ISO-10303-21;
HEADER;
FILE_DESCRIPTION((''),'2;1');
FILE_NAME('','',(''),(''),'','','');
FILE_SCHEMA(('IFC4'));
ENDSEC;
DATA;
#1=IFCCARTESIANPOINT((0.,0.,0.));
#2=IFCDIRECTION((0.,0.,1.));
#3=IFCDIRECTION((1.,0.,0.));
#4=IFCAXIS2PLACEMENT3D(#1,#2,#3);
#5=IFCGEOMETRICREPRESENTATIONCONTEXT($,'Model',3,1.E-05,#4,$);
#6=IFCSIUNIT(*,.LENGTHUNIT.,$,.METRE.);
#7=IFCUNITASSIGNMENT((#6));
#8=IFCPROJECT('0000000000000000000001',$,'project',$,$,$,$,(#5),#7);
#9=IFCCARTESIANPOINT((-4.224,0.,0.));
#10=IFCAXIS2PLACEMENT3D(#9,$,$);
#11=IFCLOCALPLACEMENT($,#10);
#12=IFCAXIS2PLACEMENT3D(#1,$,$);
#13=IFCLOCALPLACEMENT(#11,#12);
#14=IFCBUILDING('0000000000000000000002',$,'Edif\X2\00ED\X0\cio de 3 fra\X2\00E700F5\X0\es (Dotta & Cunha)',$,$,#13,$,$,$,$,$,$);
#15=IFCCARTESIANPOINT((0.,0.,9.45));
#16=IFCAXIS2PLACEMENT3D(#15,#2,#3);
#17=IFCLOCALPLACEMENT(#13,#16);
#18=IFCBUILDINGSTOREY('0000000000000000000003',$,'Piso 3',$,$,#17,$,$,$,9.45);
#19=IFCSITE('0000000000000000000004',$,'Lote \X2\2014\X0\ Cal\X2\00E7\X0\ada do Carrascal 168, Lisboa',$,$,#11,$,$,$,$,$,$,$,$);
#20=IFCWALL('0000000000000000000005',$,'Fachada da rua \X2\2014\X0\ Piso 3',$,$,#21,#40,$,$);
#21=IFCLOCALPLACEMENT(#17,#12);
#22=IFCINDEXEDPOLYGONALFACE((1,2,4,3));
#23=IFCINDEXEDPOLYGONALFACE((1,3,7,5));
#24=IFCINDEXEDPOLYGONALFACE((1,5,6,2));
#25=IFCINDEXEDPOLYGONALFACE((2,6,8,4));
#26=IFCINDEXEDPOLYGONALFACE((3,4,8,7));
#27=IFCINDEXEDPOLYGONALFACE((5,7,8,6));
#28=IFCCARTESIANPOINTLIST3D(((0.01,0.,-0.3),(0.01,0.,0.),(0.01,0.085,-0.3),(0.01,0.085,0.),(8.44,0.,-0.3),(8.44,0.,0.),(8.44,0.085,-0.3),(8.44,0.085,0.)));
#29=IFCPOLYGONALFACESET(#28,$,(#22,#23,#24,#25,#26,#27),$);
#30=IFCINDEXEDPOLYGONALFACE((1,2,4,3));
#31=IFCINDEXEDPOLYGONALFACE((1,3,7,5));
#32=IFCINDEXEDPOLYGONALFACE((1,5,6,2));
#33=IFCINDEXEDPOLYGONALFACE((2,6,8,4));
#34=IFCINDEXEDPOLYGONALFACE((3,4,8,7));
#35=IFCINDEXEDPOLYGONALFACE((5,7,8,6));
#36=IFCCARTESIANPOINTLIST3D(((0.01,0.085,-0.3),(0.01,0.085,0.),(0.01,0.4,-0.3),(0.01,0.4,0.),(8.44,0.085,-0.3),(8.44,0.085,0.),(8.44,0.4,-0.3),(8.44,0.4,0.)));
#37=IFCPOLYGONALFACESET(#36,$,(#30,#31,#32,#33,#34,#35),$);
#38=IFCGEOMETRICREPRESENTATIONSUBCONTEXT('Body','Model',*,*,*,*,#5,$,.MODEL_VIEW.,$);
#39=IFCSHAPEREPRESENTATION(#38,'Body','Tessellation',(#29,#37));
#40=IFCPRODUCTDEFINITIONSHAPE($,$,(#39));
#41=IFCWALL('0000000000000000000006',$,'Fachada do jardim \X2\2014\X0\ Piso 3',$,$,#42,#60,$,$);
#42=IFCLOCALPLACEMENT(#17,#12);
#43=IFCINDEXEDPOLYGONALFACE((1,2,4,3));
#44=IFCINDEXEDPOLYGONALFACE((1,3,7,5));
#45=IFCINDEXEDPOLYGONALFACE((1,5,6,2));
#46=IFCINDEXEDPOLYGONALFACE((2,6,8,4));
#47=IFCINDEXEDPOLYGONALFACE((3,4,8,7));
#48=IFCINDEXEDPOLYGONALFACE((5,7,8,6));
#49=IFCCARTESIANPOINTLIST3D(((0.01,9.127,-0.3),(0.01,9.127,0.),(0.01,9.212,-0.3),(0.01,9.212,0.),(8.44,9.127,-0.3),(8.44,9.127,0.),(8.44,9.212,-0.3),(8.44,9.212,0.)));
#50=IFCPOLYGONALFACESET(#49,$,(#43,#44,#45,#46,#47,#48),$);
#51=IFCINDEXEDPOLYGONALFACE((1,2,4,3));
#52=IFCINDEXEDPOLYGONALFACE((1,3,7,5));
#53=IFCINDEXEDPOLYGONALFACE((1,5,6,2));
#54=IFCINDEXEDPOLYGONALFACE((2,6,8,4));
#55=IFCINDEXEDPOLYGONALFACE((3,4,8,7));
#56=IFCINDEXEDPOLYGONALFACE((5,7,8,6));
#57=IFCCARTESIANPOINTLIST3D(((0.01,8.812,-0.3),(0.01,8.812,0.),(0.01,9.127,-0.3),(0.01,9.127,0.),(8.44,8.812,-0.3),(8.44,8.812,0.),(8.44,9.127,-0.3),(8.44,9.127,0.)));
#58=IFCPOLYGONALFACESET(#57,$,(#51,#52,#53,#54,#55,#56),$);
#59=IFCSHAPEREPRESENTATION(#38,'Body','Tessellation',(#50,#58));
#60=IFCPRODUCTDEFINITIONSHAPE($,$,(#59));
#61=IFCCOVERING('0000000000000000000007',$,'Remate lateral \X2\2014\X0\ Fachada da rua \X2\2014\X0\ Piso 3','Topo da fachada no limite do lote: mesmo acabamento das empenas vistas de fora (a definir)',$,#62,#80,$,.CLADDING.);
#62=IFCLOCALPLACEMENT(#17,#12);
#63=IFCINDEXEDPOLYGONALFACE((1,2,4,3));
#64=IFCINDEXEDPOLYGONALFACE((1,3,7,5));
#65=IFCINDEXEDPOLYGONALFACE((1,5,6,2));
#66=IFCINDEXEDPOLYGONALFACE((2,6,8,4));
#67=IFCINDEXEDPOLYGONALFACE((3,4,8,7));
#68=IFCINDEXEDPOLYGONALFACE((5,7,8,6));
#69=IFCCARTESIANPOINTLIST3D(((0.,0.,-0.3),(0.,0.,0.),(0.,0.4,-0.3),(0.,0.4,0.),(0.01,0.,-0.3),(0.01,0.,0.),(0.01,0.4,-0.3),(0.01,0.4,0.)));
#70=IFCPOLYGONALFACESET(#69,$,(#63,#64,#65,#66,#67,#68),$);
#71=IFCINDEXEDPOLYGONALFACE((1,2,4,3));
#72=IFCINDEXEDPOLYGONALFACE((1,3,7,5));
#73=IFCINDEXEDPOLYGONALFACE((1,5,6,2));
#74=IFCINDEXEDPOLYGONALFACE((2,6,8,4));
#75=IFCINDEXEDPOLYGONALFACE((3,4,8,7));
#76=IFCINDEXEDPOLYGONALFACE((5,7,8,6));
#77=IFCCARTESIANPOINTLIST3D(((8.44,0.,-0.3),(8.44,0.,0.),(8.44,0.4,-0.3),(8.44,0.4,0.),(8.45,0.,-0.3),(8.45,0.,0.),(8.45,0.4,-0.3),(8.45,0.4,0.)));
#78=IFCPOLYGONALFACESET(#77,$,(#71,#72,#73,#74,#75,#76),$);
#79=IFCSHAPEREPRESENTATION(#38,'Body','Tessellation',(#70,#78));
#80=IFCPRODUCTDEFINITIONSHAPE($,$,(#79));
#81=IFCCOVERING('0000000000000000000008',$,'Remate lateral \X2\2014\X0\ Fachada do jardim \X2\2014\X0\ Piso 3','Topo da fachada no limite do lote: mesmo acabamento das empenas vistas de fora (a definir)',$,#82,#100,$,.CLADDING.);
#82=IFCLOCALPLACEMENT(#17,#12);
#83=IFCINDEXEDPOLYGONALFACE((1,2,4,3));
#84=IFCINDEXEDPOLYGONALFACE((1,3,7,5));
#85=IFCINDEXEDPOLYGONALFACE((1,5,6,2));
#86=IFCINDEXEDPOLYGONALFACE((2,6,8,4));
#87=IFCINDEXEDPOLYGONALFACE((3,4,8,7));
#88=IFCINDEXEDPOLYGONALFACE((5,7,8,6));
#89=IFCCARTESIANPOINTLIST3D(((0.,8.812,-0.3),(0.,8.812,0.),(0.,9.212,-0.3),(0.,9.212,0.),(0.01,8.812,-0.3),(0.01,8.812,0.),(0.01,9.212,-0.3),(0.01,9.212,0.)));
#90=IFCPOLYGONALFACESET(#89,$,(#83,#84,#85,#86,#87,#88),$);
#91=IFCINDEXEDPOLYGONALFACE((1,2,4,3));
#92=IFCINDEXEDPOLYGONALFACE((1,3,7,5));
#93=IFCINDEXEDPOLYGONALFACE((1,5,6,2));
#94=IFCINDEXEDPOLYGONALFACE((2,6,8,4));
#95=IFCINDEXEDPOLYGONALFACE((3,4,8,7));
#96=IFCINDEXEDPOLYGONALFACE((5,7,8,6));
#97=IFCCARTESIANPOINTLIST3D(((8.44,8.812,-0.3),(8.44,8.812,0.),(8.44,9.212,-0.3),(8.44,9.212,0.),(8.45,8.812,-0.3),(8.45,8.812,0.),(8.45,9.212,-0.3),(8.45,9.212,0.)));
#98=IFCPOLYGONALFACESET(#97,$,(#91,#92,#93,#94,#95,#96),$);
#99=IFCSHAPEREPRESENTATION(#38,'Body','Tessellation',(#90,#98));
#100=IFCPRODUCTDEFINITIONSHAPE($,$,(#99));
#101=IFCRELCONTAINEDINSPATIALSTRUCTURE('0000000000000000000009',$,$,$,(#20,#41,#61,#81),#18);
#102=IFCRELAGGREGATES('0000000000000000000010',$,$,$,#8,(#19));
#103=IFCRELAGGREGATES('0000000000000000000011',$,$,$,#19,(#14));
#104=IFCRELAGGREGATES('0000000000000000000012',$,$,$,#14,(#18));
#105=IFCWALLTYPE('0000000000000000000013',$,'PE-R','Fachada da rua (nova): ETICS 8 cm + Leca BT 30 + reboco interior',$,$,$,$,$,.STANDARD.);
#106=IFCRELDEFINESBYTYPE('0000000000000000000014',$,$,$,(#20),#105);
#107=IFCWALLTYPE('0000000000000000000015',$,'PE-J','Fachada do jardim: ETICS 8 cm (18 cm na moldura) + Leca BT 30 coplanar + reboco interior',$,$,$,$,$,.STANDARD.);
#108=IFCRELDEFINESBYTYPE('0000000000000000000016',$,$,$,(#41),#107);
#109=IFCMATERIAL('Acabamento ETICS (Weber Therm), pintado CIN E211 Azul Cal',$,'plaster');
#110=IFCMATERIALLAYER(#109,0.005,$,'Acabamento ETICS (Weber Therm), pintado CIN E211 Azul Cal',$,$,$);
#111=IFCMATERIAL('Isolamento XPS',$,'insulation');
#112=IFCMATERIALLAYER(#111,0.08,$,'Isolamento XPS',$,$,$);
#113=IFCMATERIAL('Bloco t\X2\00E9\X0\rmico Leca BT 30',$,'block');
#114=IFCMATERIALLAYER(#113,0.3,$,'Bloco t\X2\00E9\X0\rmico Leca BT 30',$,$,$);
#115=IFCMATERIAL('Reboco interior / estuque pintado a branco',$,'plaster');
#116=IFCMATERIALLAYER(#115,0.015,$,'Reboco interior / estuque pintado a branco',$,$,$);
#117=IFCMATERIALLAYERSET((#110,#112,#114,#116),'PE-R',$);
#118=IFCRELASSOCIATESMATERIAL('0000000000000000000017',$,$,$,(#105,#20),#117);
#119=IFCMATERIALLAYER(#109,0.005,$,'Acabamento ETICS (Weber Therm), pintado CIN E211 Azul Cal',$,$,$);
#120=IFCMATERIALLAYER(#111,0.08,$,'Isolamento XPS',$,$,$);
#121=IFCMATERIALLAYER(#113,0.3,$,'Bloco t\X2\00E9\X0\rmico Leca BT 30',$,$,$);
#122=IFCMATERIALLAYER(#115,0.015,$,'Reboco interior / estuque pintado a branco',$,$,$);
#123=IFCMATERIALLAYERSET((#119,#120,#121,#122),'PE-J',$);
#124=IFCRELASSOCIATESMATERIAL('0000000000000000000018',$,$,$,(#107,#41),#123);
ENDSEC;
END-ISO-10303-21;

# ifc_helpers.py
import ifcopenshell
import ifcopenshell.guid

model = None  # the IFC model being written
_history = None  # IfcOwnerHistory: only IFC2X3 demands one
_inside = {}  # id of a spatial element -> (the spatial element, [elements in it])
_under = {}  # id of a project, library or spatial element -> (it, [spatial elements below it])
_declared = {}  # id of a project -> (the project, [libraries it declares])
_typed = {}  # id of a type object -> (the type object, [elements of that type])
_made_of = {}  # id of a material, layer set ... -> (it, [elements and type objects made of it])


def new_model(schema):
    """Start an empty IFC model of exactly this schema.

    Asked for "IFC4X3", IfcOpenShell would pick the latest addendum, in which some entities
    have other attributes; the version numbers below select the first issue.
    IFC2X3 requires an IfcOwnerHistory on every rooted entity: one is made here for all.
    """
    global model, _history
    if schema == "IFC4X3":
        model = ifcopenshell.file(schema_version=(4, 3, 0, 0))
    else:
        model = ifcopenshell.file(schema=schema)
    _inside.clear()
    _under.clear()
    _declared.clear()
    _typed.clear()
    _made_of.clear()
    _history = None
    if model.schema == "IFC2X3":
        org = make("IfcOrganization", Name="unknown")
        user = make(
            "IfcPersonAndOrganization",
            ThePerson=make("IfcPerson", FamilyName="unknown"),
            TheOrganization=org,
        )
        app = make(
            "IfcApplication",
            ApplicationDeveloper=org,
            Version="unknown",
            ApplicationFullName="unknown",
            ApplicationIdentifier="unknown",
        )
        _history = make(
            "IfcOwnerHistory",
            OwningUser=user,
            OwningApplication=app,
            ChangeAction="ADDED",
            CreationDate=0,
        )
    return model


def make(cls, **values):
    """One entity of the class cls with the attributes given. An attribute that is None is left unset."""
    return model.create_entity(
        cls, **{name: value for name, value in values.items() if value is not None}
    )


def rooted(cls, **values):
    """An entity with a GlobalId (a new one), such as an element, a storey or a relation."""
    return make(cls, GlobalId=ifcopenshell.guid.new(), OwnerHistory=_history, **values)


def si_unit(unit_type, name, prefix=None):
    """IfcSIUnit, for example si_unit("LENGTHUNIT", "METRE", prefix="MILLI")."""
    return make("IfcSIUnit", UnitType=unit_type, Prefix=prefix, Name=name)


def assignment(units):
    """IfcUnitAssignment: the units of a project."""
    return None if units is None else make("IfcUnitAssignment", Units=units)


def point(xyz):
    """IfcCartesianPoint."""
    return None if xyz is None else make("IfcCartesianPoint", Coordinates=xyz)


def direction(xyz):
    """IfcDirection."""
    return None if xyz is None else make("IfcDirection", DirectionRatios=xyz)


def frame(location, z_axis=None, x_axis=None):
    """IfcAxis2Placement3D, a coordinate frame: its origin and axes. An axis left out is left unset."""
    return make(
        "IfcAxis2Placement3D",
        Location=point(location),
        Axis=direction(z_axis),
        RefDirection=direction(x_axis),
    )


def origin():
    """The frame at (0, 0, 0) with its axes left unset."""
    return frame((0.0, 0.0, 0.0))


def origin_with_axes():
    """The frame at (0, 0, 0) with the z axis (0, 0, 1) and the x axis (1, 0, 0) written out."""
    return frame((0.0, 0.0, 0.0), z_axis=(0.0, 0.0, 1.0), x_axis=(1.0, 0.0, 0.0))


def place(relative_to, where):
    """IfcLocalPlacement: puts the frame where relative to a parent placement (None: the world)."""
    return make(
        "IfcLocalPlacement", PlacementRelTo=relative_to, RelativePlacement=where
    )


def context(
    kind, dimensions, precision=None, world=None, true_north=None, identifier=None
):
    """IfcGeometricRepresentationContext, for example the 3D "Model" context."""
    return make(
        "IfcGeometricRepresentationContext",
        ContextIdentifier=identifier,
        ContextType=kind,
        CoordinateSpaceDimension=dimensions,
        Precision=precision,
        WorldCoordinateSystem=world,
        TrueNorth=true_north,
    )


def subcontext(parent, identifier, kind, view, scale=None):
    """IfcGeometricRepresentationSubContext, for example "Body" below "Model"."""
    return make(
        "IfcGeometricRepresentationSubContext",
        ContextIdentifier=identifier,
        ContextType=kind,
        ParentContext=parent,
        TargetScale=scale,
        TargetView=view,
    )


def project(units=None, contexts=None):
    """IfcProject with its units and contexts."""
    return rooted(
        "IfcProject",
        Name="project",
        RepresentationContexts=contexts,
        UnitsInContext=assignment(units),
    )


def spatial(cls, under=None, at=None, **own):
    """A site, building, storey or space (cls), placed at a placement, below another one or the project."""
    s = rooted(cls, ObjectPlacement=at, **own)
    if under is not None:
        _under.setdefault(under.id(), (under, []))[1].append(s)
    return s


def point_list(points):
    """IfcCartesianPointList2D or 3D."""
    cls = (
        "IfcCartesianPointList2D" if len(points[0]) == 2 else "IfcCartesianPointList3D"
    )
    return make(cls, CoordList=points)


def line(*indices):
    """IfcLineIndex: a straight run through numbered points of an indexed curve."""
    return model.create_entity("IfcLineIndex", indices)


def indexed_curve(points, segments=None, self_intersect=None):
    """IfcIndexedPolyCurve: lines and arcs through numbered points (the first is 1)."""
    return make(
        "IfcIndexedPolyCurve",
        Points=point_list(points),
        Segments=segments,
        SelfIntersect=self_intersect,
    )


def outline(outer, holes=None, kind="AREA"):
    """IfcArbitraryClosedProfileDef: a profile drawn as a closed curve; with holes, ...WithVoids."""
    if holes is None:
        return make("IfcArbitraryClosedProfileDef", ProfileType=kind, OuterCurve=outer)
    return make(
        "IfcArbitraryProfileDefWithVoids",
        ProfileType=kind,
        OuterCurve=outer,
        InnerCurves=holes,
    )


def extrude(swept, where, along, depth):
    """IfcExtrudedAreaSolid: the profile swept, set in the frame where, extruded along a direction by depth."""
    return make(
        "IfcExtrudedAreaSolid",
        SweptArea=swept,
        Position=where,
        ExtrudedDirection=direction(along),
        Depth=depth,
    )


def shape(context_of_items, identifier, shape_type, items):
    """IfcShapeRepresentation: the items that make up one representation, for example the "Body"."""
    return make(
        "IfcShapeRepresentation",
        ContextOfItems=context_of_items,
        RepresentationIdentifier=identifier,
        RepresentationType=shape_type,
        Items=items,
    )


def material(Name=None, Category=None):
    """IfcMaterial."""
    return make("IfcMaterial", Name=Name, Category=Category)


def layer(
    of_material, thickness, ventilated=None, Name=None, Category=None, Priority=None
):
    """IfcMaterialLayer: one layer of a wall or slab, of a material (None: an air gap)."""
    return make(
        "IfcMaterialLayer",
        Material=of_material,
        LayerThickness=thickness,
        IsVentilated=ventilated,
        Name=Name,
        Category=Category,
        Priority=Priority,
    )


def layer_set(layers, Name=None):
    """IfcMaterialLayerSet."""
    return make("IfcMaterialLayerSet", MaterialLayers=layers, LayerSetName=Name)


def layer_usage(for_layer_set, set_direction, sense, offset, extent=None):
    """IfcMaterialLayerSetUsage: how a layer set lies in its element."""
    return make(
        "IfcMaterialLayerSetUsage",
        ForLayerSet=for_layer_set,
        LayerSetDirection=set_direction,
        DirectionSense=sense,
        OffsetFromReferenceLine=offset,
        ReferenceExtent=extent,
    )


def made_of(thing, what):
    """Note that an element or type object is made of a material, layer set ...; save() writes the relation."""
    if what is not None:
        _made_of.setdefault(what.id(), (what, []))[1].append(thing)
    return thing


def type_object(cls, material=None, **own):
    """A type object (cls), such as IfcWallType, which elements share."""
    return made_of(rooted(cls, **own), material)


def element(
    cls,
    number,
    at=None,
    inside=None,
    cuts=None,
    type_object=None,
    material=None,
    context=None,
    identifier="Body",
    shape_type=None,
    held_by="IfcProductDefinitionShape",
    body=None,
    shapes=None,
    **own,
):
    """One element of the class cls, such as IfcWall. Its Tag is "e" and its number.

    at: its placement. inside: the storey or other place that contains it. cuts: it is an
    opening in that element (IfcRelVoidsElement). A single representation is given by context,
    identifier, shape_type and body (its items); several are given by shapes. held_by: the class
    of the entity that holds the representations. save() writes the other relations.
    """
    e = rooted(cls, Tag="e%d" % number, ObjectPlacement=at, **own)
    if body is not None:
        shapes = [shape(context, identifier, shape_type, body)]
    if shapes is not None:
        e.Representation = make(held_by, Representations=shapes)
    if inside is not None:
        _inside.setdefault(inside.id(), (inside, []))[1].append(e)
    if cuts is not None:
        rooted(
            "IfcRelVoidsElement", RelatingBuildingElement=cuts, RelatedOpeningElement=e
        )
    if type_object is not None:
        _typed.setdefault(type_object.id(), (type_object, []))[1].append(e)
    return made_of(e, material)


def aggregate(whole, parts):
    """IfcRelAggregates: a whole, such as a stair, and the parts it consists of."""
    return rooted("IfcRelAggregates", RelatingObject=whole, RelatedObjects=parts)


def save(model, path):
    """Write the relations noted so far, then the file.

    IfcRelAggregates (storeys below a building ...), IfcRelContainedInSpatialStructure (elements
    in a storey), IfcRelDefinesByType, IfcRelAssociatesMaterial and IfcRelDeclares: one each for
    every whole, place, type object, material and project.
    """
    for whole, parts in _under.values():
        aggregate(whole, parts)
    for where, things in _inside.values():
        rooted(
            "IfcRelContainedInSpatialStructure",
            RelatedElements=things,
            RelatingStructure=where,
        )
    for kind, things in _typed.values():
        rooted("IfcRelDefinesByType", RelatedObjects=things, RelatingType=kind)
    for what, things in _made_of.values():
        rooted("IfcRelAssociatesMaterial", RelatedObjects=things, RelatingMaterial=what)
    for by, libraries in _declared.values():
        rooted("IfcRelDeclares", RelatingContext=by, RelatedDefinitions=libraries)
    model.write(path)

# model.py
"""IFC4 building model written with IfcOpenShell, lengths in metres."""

from ifc_helpers import new_model, si_unit, frame, origin, origin_with_axes, place, context, subcontext, project, spatial, line, indexed_curve, outline, extrude, material, layer, layer_set, layer_usage, type_object, element, save


model = new_model("IFC4")

# Units and contexts
model_context = context("Model", 3, precision=1e-05, world=origin_with_axes())
body_context = subcontext(model_context, "Body", "Model", "MODEL_VIEW")
ifc_project = project(units=[si_unit("LENGTHUNIT", "METRE")], contexts=[model_context])

# Site, building, storey
site_placement = place(None, frame((-4.224, 0.0, 0.0)))
site = spatial("IfcSite", under=ifc_project, at=site_placement, Name="Lote — Calçada do Carrascal 168, Lisboa")
building_placement = place(site_placement, origin())
building = spatial("IfcBuilding", under=site, at=building_placement, Name="Edifício de 3 frações (Dotta & Cunha)")
storey_placement = place(building_placement, frame((0.0, 0.0, 9.45), z_axis=(0.0, 0.0, 1.0), x_axis=(1.0, 0.0, 0.0)))
storey = spatial("IfcBuildingStorey", under=building, at=storey_placement, Name="Piso 3", Elevation=9.45)

# Walls
ifc_material_1 = material(Name="Acabamento ETICS (Weber Therm), pintado CIN E211 Azul Cal", Category="plaster")
ifc_layer_1 = layer(ifc_material_1, 0.005, Name="Acabamento ETICS (Weber Therm), pintado CIN E211 Azul Cal")
ifc_material_2 = material(Name="Isolamento XPS", Category="insulation")
ifc_layer_2 = layer(ifc_material_2, 0.08, Name="Isolamento XPS")
ifc_material_3 = material(Name="Bloco térmico Leca BT 30", Category="block")
ifc_layer_3 = layer(ifc_material_3, 0.3, Name="Bloco térmico Leca BT 30")
ifc_material_4 = material(Name="Reboco interior / estuque pintado a branco", Category="plaster")
ifc_layer_4 = layer(ifc_material_4, 0.015, Name="Reboco interior / estuque pintado a branco")
ifc_layer_set_1 = layer_set([ifc_layer_1, ifc_layer_2, ifc_layer_3, ifc_layer_4], Name="PE-R")
ifc_layer_usage_1 = layer_usage(ifc_layer_set_1, "AXIS2", "POSITIVE", 0.0)
wall_type_1 = type_object("IfcWallType", Name="PE-R", Description="Fachada da rua (nova): ETICS 8 cm + Leca BT 30 + reboco interior", PredefinedType="STANDARD", material=ifc_layer_set_1)
wall_1_placement = place(storey_placement, frame((0.0, 0.0, -0.3), z_axis=(0.0, 0.0, 1.0), x_axis=(1.0, 0.0, 0.0)))
element("IfcWall", 1, at=wall_1_placement, inside=storey, type_object=wall_type_1, material=ifc_layer_usage_1, Name="Fachada da rua — Piso 3", context=body_context, shape_type="SweptSolid", body=[
    extrude(outline(indexed_curve([(8.44, 0.0), (0.01, 0.0), (0.01, 0.085), (8.44, 0.085)], segments=[line(1, 2, 3, 4, 1)])), origin_with_axes(), (0.0, 0.0, 1.0), 0.3),
    extrude(outline(indexed_curve([(0.01, 0.4), (8.44, 0.4), (8.44, 0.085), (0.01, 0.085)], segments=[line(1, 2, 3, 4, 1)])), origin_with_axes(), (0.0, 0.0, 1.0), 0.3),
])
ifc_layer_5 = layer(ifc_material_1, 0.005, Name="Acabamento ETICS (Weber Therm), pintado CIN E211 Azul Cal")
ifc_layer_6 = layer(ifc_material_2, 0.08, Name="Isolamento XPS")
ifc_layer_7 = layer(ifc_material_3, 0.3, Name="Bloco térmico Leca BT 30")
ifc_layer_8 = layer(ifc_material_4, 0.015, Name="Reboco interior / estuque pintado a branco")
ifc_layer_set_2 = layer_set([ifc_layer_5, ifc_layer_6, ifc_layer_7, ifc_layer_8], Name="PE-J")
ifc_layer_usage_2 = layer_usage(ifc_layer_set_2, "AXIS2", "NEGATIVE", 9.212)
wall_type_2 = type_object("IfcWallType", Name="PE-J", Description="Fachada do jardim: ETICS 8 cm (18 cm na moldura) + Leca BT 30 coplanar + reboco interior", PredefinedType="STANDARD", material=ifc_layer_set_2)
wall_2_placement = place(storey_placement, frame((0.0, 0.0, -0.3), z_axis=(0.0, 0.0, 1.0), x_axis=(1.0, 0.0, 0.0)))
element("IfcWall", 2, at=wall_2_placement, inside=storey, type_object=wall_type_2, material=ifc_layer_usage_2, Name="Fachada do jardim — Piso 3", context=body_context, shape_type="SweptSolid", body=[
    extrude(outline(indexed_curve([(8.44, 9.127), (0.01, 9.127), (0.01, 9.212), (8.44, 9.212)], segments=[line(1, 2, 3, 4, 1)])), origin_with_axes(), (0.0, 0.0, 1.0), 0.3),
    extrude(outline(indexed_curve([(8.44, 8.812), (0.01, 8.812), (0.01, 9.127), (8.44, 9.127)], segments=[line(1, 2, 3, 4, 1)])), origin_with_axes(), (0.0, 0.0, 1.0), 0.3),
])

# Coverings
covering_1_placement = place(storey_placement, frame((0.0, 0.0, -0.3), z_axis=(0.0, 0.0, 1.0), x_axis=(1.0, 0.0, 0.0)))
element("IfcCovering", 3, at=covering_1_placement, inside=storey, Name="Remate lateral — Fachada da rua — Piso 3", Description="Topo da fachada no limite do lote: mesmo acabamento das empenas vistas de fora (a definir)", PredefinedType="CLADDING", context=body_context, shape_type="SweptSolid", body=[
    extrude(outline(indexed_curve([(0.0, 0.0), (0.0, 0.4), (0.01, 0.4), (0.01, 0.0)], segments=[line(1, 2, 3, 4, 1)])), origin_with_axes(), (0.0, 0.0, 1.0), 0.3),
    extrude(outline(indexed_curve([(8.44, 0.0), (8.44, 0.4), (8.45, 0.4), (8.45, 0.0)], segments=[line(1, 2, 3, 4, 1)])), origin_with_axes(), (0.0, 0.0, 1.0), 0.3),
])
covering_2_placement = place(storey_placement, frame((0.0, 0.0, -0.3), z_axis=(0.0, 0.0, 1.0), x_axis=(1.0, 0.0, 0.0)))
element("IfcCovering", 4, at=covering_2_placement, inside=storey, Name="Remate lateral — Fachada do jardim — Piso 3", Description="Topo da fachada no limite do lote: mesmo acabamento das empenas vistas de fora (a definir)", PredefinedType="CLADDING", context=body_context, shape_type="SweptSolid", body=[
    extrude(outline(indexed_curve([(0.0, 8.812), (0.0, 9.212), (0.01, 9.212), (0.01, 8.812)], segments=[line(1, 2, 3, 4, 1)])), origin_with_axes(), (0.0, 0.0, 1.0), 0.3),
    extrude(outline(indexed_curve([(8.44, 8.812), (8.44, 9.212), (8.45, 9.212), (8.45, 8.812)], segments=[line(1, 2, 3, 4, 1)])), origin_with_axes(), (0.0, 0.0, 1.0), 0.3),
])

save(model, "model.ifc")
